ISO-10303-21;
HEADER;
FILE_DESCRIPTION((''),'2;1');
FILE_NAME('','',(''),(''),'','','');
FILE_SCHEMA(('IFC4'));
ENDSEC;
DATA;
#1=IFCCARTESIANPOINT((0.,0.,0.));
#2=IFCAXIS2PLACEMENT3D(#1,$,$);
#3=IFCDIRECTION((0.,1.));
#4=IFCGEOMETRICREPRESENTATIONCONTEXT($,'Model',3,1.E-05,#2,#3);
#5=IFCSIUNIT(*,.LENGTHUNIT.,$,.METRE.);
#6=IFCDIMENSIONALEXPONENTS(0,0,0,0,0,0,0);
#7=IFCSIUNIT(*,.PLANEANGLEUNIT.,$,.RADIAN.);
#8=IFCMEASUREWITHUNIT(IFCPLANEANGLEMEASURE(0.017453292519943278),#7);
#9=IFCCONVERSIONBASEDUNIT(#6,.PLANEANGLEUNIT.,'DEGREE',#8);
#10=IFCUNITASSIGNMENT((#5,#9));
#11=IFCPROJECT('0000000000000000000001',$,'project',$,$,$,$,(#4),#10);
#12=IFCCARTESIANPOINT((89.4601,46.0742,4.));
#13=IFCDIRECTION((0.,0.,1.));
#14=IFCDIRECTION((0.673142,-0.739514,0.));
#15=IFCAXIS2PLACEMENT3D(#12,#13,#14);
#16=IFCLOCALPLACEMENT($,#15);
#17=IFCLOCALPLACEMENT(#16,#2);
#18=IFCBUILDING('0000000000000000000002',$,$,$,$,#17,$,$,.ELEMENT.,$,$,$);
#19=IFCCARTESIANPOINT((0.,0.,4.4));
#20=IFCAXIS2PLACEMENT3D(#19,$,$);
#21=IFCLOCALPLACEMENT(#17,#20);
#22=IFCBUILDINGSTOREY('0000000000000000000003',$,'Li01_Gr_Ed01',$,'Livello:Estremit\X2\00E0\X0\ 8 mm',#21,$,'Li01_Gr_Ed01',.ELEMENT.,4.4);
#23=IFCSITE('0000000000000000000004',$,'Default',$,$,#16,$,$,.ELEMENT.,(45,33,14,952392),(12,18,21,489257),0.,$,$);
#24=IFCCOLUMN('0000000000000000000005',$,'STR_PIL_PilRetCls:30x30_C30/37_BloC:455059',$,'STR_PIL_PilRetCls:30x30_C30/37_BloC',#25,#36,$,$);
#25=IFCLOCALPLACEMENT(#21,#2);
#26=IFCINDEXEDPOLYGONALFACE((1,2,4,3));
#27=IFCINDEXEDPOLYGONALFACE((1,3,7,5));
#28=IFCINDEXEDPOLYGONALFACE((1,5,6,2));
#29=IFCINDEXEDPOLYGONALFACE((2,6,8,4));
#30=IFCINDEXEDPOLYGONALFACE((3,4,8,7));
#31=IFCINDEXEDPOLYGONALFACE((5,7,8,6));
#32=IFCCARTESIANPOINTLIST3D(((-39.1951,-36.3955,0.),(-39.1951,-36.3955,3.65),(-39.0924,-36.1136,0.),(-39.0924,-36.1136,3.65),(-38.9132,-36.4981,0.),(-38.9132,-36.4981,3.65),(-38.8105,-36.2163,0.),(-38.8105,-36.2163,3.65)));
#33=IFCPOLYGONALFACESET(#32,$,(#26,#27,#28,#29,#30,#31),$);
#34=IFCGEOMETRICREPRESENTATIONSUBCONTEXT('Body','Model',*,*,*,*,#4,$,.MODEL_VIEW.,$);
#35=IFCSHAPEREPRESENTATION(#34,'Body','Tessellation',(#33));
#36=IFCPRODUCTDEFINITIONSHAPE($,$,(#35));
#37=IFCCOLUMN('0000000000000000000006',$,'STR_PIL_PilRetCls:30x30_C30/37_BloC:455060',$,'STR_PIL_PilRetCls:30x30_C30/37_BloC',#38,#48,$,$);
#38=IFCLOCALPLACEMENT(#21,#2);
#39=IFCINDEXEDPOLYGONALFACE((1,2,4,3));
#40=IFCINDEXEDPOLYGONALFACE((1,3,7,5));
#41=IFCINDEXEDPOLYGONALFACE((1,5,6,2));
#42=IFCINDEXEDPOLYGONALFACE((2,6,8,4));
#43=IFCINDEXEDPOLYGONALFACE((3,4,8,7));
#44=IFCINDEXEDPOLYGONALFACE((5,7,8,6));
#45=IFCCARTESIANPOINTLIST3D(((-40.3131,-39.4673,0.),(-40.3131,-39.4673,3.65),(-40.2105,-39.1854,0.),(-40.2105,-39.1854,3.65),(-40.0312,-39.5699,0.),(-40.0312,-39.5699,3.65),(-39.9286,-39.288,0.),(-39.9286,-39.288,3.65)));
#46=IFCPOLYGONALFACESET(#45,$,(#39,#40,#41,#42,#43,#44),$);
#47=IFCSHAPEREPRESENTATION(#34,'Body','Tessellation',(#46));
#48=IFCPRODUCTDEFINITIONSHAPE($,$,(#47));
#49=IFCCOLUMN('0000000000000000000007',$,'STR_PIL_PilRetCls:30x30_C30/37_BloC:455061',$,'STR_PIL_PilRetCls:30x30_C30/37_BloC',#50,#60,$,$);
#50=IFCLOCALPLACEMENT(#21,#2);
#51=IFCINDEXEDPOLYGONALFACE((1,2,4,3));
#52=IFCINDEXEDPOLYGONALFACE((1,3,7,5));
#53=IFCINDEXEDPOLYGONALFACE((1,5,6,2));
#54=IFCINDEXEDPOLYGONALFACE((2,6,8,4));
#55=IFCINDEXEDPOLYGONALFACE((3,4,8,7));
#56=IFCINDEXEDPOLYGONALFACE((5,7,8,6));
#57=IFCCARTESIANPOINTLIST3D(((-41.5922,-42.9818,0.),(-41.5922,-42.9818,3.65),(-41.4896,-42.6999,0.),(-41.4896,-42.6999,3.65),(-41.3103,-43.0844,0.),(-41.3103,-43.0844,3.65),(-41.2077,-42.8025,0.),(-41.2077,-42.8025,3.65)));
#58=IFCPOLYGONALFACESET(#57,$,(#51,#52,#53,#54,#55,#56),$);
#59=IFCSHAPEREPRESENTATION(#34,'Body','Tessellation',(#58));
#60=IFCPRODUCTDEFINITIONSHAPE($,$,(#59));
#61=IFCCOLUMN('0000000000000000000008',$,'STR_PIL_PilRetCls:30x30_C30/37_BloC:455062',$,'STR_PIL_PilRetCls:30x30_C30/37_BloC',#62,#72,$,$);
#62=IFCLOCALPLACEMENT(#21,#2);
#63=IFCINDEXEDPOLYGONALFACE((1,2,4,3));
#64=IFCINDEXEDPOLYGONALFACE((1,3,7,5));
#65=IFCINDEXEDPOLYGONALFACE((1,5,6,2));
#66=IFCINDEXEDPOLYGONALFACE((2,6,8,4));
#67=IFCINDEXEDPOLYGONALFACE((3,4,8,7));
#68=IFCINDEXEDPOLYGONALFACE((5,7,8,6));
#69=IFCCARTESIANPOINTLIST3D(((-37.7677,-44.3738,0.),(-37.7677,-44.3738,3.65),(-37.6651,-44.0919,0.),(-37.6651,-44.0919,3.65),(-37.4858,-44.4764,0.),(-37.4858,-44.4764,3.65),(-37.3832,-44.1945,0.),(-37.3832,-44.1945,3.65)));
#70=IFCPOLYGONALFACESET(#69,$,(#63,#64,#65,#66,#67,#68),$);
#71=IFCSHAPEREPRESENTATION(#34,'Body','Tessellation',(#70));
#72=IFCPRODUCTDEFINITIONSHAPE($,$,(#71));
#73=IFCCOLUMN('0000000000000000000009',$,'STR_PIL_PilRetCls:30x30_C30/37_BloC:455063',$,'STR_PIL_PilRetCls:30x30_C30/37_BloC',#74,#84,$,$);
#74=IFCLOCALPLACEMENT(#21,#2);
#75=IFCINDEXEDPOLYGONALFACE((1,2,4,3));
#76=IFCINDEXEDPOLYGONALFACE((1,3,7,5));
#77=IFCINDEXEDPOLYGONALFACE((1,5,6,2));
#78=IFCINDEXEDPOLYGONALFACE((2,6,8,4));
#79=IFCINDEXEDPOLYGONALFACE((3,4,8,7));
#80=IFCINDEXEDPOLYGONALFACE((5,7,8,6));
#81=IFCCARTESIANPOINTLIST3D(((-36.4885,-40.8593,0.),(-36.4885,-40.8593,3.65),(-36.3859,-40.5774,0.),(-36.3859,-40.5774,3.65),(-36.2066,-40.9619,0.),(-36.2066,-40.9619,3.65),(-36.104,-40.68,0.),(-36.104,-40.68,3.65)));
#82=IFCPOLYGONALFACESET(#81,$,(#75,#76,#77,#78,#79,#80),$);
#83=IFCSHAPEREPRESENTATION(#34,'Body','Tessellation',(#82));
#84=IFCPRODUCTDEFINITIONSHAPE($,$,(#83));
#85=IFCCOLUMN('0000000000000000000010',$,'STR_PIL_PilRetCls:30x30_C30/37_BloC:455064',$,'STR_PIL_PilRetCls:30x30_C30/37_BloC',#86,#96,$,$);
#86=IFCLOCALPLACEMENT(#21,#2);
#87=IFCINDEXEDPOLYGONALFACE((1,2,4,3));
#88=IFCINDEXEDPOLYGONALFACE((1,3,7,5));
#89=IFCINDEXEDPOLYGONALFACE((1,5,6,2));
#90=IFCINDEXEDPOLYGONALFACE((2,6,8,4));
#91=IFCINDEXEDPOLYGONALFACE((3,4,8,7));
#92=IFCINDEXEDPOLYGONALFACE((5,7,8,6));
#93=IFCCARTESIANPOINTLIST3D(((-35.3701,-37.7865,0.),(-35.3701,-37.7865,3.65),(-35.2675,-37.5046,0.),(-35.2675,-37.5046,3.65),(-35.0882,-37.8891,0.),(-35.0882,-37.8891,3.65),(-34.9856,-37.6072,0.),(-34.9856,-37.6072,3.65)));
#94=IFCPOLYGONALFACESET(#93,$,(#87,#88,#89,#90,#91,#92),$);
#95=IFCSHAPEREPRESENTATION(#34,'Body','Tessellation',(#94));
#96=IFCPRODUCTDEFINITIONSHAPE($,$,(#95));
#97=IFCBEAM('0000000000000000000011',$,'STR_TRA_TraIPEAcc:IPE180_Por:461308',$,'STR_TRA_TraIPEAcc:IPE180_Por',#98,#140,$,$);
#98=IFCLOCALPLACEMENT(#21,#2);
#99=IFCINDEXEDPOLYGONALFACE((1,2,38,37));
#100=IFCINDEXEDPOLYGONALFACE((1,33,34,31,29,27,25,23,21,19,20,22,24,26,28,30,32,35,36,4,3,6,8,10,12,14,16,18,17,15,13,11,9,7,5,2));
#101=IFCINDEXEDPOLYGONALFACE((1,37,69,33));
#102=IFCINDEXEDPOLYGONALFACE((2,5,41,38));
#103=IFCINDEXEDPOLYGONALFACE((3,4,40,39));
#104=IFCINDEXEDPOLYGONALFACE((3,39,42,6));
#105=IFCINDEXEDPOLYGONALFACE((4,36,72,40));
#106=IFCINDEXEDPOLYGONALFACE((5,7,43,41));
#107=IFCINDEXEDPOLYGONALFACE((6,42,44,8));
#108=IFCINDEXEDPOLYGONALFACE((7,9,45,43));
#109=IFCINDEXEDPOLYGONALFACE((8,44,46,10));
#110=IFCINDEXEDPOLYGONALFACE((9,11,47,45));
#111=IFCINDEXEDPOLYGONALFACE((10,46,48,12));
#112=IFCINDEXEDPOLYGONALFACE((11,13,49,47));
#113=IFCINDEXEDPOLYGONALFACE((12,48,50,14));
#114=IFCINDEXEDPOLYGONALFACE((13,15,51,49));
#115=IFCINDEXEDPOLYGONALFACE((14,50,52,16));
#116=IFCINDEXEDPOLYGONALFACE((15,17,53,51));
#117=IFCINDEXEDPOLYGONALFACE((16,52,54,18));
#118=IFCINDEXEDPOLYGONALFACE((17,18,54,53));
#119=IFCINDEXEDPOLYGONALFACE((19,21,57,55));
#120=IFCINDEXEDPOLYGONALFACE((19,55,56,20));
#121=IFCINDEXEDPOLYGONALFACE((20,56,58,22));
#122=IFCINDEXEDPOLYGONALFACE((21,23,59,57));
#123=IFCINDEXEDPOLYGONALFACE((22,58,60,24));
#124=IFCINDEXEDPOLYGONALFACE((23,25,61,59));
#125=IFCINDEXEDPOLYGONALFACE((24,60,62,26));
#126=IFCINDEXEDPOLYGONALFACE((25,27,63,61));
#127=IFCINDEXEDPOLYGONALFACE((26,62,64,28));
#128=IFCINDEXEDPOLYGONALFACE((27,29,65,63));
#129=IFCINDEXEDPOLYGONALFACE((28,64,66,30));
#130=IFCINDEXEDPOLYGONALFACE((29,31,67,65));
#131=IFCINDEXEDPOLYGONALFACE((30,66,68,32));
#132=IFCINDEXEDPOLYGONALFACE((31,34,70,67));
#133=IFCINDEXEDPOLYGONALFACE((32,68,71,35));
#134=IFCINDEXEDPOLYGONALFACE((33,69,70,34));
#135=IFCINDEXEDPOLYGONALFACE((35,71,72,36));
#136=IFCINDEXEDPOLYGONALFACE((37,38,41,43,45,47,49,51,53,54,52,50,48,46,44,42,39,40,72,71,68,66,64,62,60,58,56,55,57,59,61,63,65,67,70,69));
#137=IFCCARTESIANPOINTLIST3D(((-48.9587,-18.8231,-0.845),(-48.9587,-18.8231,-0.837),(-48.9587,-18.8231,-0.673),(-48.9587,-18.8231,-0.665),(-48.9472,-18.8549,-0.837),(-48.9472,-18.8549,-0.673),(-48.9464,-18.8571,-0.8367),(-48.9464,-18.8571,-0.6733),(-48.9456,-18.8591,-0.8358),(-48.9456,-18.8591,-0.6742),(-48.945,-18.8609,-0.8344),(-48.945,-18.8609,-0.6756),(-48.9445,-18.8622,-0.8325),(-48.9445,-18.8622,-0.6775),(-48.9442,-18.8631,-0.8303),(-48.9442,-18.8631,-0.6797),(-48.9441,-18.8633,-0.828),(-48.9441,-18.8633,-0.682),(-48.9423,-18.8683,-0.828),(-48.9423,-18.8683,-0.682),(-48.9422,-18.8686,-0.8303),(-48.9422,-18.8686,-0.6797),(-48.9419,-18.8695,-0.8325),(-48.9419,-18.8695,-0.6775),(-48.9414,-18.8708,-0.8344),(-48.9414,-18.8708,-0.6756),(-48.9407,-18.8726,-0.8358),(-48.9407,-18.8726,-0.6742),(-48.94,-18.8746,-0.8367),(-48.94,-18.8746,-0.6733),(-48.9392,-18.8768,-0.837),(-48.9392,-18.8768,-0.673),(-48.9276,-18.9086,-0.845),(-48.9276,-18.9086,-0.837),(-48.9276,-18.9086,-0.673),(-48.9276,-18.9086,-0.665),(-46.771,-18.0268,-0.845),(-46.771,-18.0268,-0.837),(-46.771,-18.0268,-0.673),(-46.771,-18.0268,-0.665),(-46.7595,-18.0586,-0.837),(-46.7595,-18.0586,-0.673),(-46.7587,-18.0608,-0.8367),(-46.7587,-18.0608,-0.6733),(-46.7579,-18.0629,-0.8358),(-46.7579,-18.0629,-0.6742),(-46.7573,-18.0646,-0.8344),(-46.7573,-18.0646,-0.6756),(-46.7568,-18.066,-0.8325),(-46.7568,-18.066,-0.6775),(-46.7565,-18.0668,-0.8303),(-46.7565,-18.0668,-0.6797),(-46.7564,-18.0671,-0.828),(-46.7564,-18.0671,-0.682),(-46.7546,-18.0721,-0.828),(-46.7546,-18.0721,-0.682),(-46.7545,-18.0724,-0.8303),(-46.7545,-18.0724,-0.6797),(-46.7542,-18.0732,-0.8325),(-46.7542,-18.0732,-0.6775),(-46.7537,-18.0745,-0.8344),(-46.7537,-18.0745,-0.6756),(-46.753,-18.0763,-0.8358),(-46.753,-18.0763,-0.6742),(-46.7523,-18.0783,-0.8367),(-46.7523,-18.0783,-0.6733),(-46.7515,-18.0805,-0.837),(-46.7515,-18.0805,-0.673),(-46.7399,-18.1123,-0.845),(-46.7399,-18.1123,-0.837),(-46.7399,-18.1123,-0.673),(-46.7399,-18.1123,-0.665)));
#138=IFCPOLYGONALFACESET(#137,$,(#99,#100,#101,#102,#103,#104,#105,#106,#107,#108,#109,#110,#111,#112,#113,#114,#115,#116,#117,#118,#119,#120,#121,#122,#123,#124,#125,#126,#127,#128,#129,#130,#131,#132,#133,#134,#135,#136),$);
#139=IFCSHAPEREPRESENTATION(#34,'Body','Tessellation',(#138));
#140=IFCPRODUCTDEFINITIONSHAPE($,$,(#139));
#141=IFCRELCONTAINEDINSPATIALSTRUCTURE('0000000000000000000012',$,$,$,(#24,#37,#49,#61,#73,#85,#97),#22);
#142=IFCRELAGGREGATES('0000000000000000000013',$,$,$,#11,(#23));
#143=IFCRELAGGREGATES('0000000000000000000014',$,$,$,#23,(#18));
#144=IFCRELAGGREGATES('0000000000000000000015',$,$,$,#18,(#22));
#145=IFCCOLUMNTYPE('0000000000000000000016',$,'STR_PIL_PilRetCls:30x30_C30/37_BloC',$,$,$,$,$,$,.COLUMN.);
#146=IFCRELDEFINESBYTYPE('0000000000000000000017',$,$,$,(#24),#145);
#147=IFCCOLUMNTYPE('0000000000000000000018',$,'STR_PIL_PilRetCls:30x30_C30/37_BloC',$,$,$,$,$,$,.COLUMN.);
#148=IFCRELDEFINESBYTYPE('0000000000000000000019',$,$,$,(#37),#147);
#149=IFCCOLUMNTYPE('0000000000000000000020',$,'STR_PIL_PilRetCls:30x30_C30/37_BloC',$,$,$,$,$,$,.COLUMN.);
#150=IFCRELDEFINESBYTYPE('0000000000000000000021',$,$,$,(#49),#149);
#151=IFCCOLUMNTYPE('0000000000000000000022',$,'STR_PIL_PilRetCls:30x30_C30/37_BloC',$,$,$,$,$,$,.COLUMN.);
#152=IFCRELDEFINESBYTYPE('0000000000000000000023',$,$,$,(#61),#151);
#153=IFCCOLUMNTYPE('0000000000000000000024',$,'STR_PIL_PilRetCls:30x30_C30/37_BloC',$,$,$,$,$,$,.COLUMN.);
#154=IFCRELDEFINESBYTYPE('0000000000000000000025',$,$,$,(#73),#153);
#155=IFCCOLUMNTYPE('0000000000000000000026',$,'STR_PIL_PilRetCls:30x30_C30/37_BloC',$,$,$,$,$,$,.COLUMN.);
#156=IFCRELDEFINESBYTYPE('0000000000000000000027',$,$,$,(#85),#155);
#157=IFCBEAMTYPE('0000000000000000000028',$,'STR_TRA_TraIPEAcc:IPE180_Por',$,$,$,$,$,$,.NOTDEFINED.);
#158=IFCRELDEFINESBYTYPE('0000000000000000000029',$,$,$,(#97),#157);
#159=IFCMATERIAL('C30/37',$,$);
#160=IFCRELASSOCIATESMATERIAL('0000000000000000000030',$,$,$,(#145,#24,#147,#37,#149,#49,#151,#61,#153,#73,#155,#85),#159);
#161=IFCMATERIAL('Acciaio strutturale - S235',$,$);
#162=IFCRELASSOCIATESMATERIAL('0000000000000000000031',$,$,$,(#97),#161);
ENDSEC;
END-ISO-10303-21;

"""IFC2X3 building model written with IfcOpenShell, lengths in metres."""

from ifc_helpers import new_model, entity, si_unit, converted_unit, direction, frame, frame_2d, origin, origin_2d_with_axis, place, context, subcontext, project, spatial, rectangle, i_section, extrude, source, transform, mapped, material, type_object, type_shapes, element, save


model = new_model("IFC2X3")

# Units and contexts
model_context = context("Model", 3, precision=1e-05, world=origin(), true_north=direction((0.0, 1.0)))
body_context = subcontext(model_context, "Body", "Model", "MODEL_VIEW")
ifc_project = project(units=[si_unit("LENGTHUNIT", "METRE"), converted_unit("PLANEANGLEUNIT", "DEGREE", entity("IfcPlaneAngleMeasure", 0.017453292519943278), si_unit("PLANEANGLEUNIT", "RADIAN"), dimensions=[0, 0, 0, 0, 0, 0, 0])], contexts=[model_context])

# Site, building, storey
site_placement = place(None, frame((89.4601, 46.0742, 4.0), z_axis=(0.0, 0.0, 1.0), x_axis=(0.673142, -0.739514, 0.0)))
site = spatial("IfcSite", under=ifc_project, at=site_placement, Name="Default", CompositionType="ELEMENT", RefLatitude=(45, 33, 14, 952392), RefLongitude=(12, 18, 21, 489257), RefElevation=0.0)
building_placement = place(site_placement, origin())
building = spatial("IfcBuilding", under=site, at=building_placement, CompositionType="ELEMENT")
storey_placement = place(building_placement, frame((0.0, 0.0, 4.4)))
storey = spatial("IfcBuildingStorey", under=building, at=storey_placement, Name="Li01_Gr_Ed01", ObjectType="Livello:Estremità 8 mm", LongName="Li01_Gr_Ed01", CompositionType="ELEMENT", Elevation=4.4)

# Columns
ifc_material_1 = material(Name="C30/37")
column_type_1 = type_object("IfcColumnType", Name="STR_PIL_PilRetCls:30x30_C30/37_BloC", PredefinedType="COLUMN", material=ifc_material_1)
shared_shape_1 = source(origin(), body_context, "Body", "SweptSolid", [
    extrude(rectangle(XDim=3.65, YDim=0.3, at=frame_2d((0.0, 0.0), x_axis=(1.0, 0.0))), frame((-39.1437, -36.2545, 6.225), z_axis=(0.939597, -0.342284, 0.0), x_axis=(0.0, 0.0, 1.0)), (0.0, 0.0, 1.0), 0.3),
])
type_shapes(column_type_1, [shared_shape_1])
column_1_placement = place(storey_placement, frame((0.0, 0.0, -4.4)))
element("IfcColumn", 1, at=column_1_placement, inside=storey, type_object=column_type_1, material=ifc_material_1, Name="STR_PIL_PilRetCls:30x30_C30/37_BloC:455059", ObjectType="STR_PIL_PilRetCls:30x30_C30/37_BloC", context=body_context, shape_type="MappedRepresentation", body=[
    mapped(shared_shape_1, transform((0.0, 0.0, 0.0), scale=1.0)),
])
column_type_2 = type_object("IfcColumnType", Name="STR_PIL_PilRetCls:30x30_C30/37_BloC", PredefinedType="COLUMN", material=ifc_material_1)
shared_shape_2 = source(origin(), body_context, "Body", "SweptSolid", [
    extrude(rectangle(XDim=3.65, YDim=0.3, at=frame_2d((0.0, 0.0), x_axis=(1.0, 0.0))), frame((-40.2618, -39.3264, 6.225), z_axis=(0.939693, -0.34202, 0.0), x_axis=(0.0, 0.0, 1.0)), (0.0, 0.0, 1.0), 0.3),
])
type_shapes(column_type_2, [shared_shape_2])
column_2_placement = place(storey_placement, frame((0.0, 0.0, -4.4)))
element("IfcColumn", 2, at=column_2_placement, inside=storey, type_object=column_type_2, material=ifc_material_1, Name="STR_PIL_PilRetCls:30x30_C30/37_BloC:455060", ObjectType="STR_PIL_PilRetCls:30x30_C30/37_BloC", context=body_context, shape_type="MappedRepresentation", body=[
    mapped(shared_shape_2, transform((0.0, 0.0, 0.0), scale=1.0)),
])
column_type_3 = type_object("IfcColumnType", Name="STR_PIL_PilRetCls:30x30_C30/37_BloC", PredefinedType="COLUMN", material=ifc_material_1)
shared_shape_3 = source(origin(), body_context, "Body", "SweptSolid", [
    extrude(rectangle(XDim=3.65, YDim=0.3, at=frame_2d((0.0, 0.0), x_axis=(1.0, 0.0))), frame((-41.5409, -42.8408, 6.225), z_axis=(0.939693, -0.34202, 0.0), x_axis=(0.0, 0.0, 1.0)), (0.0, 0.0, 1.0), 0.3),
])
type_shapes(column_type_3, [shared_shape_3])
column_3_placement = place(storey_placement, frame((0.0, 0.0, -4.4)))
element("IfcColumn", 3, at=column_3_placement, inside=storey, type_object=column_type_3, material=ifc_material_1, Name="STR_PIL_PilRetCls:30x30_C30/37_BloC:455061", ObjectType="STR_PIL_PilRetCls:30x30_C30/37_BloC", context=body_context, shape_type="MappedRepresentation", body=[
    mapped(shared_shape_3, transform((0.0, 0.0, 0.0), scale=1.0)),
])
column_type_4 = type_object("IfcColumnType", Name="STR_PIL_PilRetCls:30x30_C30/37_BloC", PredefinedType="COLUMN", material=ifc_material_1)
shared_shape_4 = source(origin(), body_context, "Body", "SweptSolid", [
    extrude(rectangle(XDim=3.65, YDim=0.3, at=frame_2d((0.0, 0.0), x_axis=(1.0, 0.0))), frame((-37.7164, -44.2328, 6.225), z_axis=(0.939693, -0.34202, 0.0), x_axis=(0.0, 0.0, 1.0)), (0.0, 0.0, 1.0), 0.3),
])
type_shapes(column_type_4, [shared_shape_4])
column_4_placement = place(storey_placement, frame((0.0, 0.0, -4.4)))
element("IfcColumn", 4, at=column_4_placement, inside=storey, type_object=column_type_4, material=ifc_material_1, Name="STR_PIL_PilRetCls:30x30_C30/37_BloC:455062", ObjectType="STR_PIL_PilRetCls:30x30_C30/37_BloC", context=body_context, shape_type="MappedRepresentation", body=[
    mapped(shared_shape_4, transform((0.0, 0.0, 0.0), scale=1.0)),
])
column_type_5 = type_object("IfcColumnType", Name="STR_PIL_PilRetCls:30x30_C30/37_BloC", PredefinedType="COLUMN", material=ifc_material_1)
shared_shape_5 = source(origin(), body_context, "Body", "SweptSolid", [
    extrude(rectangle(XDim=3.65, YDim=0.3, at=frame_2d((0.0, 0.0), x_axis=(1.0, 0.0))), frame((-36.4372, -40.7184, 6.225), z_axis=(0.939693, -0.34202, 0.0), x_axis=(0.0, 0.0, 1.0)), (0.0, 0.0, 1.0), 0.3),
])
type_shapes(column_type_5, [shared_shape_5])
column_5_placement = place(storey_placement, frame((0.0, 0.0, -4.4)))
element("IfcColumn", 5, at=column_5_placement, inside=storey, type_object=column_type_5, material=ifc_material_1, Name="STR_PIL_PilRetCls:30x30_C30/37_BloC:455063", ObjectType="STR_PIL_PilRetCls:30x30_C30/37_BloC", context=body_context, shape_type="MappedRepresentation", body=[
    mapped(shared_shape_5, transform((0.0, 0.0, 0.0), scale=1.0)),
])
column_type_6 = type_object("IfcColumnType", Name="STR_PIL_PilRetCls:30x30_C30/37_BloC", PredefinedType="COLUMN", material=ifc_material_1)
shared_shape_6 = source(origin(), body_context, "Body", "SweptSolid", [
    extrude(rectangle(XDim=3.65, YDim=0.3, at=origin_2d_with_axis()), frame((-35.3188, -37.6456, 6.225), z_axis=(0.939693, -0.34202, 0.0), x_axis=(0.0, 0.0, 1.0)), (0.0, 0.0, 1.0), 0.3),
])
type_shapes(column_type_6, [shared_shape_6])
column_6_placement = place(storey_placement, frame((0.0, 0.0, -4.4)))
element("IfcColumn", 6, at=column_6_placement, inside=storey, type_object=column_type_6, material=ifc_material_1, Name="STR_PIL_PilRetCls:30x30_C30/37_BloC:455064", ObjectType="STR_PIL_PilRetCls:30x30_C30/37_BloC", context=body_context, shape_type="MappedRepresentation", body=[
    mapped(shared_shape_6, transform((0.0, 0.0, 0.0), scale=1.0)),
])

# Beam
ifc_material_2 = material(Name="Acciaio strutturale - S235")
beam_type = type_object("IfcBeamType", Name="STR_TRA_TraIPEAcc:IPE180_Por", PredefinedType="NOTDEFINED")
beam_1_placement = place(storey_placement, frame((-49.0228, -18.8948, -0.665), z_axis=(0.0, 0.0, 1.0), x_axis=(0.939693, 0.34202, 0.0)))
element("IfcBeam", 7, at=beam_1_placement, inside=storey, type_object=beam_type, material=ifc_material_2, Name="STR_TRA_TraIPEAcc:IPE180_Por:461308", ObjectType="STR_TRA_TraIPEAcc:IPE180_Por", context=body_context, shape_type="SweptSolid", body=[
    extrude(i_section(OverallWidth=0.091, OverallDepth=0.18, WebThickness=0.0053, FlangeThickness=0.008, FilletRadius=0.009, at=frame_2d((0.0, 0.0), x_axis=(0.0, 1.0))), frame((0.0847, 0.0, -0.09), z_axis=(1.0, 0.0, 0.0), x_axis=(0.0, 0.0, -1.0)), (0.0, 0.0, 1.0), 2.3281),
])

save(model, "model.ifc")
